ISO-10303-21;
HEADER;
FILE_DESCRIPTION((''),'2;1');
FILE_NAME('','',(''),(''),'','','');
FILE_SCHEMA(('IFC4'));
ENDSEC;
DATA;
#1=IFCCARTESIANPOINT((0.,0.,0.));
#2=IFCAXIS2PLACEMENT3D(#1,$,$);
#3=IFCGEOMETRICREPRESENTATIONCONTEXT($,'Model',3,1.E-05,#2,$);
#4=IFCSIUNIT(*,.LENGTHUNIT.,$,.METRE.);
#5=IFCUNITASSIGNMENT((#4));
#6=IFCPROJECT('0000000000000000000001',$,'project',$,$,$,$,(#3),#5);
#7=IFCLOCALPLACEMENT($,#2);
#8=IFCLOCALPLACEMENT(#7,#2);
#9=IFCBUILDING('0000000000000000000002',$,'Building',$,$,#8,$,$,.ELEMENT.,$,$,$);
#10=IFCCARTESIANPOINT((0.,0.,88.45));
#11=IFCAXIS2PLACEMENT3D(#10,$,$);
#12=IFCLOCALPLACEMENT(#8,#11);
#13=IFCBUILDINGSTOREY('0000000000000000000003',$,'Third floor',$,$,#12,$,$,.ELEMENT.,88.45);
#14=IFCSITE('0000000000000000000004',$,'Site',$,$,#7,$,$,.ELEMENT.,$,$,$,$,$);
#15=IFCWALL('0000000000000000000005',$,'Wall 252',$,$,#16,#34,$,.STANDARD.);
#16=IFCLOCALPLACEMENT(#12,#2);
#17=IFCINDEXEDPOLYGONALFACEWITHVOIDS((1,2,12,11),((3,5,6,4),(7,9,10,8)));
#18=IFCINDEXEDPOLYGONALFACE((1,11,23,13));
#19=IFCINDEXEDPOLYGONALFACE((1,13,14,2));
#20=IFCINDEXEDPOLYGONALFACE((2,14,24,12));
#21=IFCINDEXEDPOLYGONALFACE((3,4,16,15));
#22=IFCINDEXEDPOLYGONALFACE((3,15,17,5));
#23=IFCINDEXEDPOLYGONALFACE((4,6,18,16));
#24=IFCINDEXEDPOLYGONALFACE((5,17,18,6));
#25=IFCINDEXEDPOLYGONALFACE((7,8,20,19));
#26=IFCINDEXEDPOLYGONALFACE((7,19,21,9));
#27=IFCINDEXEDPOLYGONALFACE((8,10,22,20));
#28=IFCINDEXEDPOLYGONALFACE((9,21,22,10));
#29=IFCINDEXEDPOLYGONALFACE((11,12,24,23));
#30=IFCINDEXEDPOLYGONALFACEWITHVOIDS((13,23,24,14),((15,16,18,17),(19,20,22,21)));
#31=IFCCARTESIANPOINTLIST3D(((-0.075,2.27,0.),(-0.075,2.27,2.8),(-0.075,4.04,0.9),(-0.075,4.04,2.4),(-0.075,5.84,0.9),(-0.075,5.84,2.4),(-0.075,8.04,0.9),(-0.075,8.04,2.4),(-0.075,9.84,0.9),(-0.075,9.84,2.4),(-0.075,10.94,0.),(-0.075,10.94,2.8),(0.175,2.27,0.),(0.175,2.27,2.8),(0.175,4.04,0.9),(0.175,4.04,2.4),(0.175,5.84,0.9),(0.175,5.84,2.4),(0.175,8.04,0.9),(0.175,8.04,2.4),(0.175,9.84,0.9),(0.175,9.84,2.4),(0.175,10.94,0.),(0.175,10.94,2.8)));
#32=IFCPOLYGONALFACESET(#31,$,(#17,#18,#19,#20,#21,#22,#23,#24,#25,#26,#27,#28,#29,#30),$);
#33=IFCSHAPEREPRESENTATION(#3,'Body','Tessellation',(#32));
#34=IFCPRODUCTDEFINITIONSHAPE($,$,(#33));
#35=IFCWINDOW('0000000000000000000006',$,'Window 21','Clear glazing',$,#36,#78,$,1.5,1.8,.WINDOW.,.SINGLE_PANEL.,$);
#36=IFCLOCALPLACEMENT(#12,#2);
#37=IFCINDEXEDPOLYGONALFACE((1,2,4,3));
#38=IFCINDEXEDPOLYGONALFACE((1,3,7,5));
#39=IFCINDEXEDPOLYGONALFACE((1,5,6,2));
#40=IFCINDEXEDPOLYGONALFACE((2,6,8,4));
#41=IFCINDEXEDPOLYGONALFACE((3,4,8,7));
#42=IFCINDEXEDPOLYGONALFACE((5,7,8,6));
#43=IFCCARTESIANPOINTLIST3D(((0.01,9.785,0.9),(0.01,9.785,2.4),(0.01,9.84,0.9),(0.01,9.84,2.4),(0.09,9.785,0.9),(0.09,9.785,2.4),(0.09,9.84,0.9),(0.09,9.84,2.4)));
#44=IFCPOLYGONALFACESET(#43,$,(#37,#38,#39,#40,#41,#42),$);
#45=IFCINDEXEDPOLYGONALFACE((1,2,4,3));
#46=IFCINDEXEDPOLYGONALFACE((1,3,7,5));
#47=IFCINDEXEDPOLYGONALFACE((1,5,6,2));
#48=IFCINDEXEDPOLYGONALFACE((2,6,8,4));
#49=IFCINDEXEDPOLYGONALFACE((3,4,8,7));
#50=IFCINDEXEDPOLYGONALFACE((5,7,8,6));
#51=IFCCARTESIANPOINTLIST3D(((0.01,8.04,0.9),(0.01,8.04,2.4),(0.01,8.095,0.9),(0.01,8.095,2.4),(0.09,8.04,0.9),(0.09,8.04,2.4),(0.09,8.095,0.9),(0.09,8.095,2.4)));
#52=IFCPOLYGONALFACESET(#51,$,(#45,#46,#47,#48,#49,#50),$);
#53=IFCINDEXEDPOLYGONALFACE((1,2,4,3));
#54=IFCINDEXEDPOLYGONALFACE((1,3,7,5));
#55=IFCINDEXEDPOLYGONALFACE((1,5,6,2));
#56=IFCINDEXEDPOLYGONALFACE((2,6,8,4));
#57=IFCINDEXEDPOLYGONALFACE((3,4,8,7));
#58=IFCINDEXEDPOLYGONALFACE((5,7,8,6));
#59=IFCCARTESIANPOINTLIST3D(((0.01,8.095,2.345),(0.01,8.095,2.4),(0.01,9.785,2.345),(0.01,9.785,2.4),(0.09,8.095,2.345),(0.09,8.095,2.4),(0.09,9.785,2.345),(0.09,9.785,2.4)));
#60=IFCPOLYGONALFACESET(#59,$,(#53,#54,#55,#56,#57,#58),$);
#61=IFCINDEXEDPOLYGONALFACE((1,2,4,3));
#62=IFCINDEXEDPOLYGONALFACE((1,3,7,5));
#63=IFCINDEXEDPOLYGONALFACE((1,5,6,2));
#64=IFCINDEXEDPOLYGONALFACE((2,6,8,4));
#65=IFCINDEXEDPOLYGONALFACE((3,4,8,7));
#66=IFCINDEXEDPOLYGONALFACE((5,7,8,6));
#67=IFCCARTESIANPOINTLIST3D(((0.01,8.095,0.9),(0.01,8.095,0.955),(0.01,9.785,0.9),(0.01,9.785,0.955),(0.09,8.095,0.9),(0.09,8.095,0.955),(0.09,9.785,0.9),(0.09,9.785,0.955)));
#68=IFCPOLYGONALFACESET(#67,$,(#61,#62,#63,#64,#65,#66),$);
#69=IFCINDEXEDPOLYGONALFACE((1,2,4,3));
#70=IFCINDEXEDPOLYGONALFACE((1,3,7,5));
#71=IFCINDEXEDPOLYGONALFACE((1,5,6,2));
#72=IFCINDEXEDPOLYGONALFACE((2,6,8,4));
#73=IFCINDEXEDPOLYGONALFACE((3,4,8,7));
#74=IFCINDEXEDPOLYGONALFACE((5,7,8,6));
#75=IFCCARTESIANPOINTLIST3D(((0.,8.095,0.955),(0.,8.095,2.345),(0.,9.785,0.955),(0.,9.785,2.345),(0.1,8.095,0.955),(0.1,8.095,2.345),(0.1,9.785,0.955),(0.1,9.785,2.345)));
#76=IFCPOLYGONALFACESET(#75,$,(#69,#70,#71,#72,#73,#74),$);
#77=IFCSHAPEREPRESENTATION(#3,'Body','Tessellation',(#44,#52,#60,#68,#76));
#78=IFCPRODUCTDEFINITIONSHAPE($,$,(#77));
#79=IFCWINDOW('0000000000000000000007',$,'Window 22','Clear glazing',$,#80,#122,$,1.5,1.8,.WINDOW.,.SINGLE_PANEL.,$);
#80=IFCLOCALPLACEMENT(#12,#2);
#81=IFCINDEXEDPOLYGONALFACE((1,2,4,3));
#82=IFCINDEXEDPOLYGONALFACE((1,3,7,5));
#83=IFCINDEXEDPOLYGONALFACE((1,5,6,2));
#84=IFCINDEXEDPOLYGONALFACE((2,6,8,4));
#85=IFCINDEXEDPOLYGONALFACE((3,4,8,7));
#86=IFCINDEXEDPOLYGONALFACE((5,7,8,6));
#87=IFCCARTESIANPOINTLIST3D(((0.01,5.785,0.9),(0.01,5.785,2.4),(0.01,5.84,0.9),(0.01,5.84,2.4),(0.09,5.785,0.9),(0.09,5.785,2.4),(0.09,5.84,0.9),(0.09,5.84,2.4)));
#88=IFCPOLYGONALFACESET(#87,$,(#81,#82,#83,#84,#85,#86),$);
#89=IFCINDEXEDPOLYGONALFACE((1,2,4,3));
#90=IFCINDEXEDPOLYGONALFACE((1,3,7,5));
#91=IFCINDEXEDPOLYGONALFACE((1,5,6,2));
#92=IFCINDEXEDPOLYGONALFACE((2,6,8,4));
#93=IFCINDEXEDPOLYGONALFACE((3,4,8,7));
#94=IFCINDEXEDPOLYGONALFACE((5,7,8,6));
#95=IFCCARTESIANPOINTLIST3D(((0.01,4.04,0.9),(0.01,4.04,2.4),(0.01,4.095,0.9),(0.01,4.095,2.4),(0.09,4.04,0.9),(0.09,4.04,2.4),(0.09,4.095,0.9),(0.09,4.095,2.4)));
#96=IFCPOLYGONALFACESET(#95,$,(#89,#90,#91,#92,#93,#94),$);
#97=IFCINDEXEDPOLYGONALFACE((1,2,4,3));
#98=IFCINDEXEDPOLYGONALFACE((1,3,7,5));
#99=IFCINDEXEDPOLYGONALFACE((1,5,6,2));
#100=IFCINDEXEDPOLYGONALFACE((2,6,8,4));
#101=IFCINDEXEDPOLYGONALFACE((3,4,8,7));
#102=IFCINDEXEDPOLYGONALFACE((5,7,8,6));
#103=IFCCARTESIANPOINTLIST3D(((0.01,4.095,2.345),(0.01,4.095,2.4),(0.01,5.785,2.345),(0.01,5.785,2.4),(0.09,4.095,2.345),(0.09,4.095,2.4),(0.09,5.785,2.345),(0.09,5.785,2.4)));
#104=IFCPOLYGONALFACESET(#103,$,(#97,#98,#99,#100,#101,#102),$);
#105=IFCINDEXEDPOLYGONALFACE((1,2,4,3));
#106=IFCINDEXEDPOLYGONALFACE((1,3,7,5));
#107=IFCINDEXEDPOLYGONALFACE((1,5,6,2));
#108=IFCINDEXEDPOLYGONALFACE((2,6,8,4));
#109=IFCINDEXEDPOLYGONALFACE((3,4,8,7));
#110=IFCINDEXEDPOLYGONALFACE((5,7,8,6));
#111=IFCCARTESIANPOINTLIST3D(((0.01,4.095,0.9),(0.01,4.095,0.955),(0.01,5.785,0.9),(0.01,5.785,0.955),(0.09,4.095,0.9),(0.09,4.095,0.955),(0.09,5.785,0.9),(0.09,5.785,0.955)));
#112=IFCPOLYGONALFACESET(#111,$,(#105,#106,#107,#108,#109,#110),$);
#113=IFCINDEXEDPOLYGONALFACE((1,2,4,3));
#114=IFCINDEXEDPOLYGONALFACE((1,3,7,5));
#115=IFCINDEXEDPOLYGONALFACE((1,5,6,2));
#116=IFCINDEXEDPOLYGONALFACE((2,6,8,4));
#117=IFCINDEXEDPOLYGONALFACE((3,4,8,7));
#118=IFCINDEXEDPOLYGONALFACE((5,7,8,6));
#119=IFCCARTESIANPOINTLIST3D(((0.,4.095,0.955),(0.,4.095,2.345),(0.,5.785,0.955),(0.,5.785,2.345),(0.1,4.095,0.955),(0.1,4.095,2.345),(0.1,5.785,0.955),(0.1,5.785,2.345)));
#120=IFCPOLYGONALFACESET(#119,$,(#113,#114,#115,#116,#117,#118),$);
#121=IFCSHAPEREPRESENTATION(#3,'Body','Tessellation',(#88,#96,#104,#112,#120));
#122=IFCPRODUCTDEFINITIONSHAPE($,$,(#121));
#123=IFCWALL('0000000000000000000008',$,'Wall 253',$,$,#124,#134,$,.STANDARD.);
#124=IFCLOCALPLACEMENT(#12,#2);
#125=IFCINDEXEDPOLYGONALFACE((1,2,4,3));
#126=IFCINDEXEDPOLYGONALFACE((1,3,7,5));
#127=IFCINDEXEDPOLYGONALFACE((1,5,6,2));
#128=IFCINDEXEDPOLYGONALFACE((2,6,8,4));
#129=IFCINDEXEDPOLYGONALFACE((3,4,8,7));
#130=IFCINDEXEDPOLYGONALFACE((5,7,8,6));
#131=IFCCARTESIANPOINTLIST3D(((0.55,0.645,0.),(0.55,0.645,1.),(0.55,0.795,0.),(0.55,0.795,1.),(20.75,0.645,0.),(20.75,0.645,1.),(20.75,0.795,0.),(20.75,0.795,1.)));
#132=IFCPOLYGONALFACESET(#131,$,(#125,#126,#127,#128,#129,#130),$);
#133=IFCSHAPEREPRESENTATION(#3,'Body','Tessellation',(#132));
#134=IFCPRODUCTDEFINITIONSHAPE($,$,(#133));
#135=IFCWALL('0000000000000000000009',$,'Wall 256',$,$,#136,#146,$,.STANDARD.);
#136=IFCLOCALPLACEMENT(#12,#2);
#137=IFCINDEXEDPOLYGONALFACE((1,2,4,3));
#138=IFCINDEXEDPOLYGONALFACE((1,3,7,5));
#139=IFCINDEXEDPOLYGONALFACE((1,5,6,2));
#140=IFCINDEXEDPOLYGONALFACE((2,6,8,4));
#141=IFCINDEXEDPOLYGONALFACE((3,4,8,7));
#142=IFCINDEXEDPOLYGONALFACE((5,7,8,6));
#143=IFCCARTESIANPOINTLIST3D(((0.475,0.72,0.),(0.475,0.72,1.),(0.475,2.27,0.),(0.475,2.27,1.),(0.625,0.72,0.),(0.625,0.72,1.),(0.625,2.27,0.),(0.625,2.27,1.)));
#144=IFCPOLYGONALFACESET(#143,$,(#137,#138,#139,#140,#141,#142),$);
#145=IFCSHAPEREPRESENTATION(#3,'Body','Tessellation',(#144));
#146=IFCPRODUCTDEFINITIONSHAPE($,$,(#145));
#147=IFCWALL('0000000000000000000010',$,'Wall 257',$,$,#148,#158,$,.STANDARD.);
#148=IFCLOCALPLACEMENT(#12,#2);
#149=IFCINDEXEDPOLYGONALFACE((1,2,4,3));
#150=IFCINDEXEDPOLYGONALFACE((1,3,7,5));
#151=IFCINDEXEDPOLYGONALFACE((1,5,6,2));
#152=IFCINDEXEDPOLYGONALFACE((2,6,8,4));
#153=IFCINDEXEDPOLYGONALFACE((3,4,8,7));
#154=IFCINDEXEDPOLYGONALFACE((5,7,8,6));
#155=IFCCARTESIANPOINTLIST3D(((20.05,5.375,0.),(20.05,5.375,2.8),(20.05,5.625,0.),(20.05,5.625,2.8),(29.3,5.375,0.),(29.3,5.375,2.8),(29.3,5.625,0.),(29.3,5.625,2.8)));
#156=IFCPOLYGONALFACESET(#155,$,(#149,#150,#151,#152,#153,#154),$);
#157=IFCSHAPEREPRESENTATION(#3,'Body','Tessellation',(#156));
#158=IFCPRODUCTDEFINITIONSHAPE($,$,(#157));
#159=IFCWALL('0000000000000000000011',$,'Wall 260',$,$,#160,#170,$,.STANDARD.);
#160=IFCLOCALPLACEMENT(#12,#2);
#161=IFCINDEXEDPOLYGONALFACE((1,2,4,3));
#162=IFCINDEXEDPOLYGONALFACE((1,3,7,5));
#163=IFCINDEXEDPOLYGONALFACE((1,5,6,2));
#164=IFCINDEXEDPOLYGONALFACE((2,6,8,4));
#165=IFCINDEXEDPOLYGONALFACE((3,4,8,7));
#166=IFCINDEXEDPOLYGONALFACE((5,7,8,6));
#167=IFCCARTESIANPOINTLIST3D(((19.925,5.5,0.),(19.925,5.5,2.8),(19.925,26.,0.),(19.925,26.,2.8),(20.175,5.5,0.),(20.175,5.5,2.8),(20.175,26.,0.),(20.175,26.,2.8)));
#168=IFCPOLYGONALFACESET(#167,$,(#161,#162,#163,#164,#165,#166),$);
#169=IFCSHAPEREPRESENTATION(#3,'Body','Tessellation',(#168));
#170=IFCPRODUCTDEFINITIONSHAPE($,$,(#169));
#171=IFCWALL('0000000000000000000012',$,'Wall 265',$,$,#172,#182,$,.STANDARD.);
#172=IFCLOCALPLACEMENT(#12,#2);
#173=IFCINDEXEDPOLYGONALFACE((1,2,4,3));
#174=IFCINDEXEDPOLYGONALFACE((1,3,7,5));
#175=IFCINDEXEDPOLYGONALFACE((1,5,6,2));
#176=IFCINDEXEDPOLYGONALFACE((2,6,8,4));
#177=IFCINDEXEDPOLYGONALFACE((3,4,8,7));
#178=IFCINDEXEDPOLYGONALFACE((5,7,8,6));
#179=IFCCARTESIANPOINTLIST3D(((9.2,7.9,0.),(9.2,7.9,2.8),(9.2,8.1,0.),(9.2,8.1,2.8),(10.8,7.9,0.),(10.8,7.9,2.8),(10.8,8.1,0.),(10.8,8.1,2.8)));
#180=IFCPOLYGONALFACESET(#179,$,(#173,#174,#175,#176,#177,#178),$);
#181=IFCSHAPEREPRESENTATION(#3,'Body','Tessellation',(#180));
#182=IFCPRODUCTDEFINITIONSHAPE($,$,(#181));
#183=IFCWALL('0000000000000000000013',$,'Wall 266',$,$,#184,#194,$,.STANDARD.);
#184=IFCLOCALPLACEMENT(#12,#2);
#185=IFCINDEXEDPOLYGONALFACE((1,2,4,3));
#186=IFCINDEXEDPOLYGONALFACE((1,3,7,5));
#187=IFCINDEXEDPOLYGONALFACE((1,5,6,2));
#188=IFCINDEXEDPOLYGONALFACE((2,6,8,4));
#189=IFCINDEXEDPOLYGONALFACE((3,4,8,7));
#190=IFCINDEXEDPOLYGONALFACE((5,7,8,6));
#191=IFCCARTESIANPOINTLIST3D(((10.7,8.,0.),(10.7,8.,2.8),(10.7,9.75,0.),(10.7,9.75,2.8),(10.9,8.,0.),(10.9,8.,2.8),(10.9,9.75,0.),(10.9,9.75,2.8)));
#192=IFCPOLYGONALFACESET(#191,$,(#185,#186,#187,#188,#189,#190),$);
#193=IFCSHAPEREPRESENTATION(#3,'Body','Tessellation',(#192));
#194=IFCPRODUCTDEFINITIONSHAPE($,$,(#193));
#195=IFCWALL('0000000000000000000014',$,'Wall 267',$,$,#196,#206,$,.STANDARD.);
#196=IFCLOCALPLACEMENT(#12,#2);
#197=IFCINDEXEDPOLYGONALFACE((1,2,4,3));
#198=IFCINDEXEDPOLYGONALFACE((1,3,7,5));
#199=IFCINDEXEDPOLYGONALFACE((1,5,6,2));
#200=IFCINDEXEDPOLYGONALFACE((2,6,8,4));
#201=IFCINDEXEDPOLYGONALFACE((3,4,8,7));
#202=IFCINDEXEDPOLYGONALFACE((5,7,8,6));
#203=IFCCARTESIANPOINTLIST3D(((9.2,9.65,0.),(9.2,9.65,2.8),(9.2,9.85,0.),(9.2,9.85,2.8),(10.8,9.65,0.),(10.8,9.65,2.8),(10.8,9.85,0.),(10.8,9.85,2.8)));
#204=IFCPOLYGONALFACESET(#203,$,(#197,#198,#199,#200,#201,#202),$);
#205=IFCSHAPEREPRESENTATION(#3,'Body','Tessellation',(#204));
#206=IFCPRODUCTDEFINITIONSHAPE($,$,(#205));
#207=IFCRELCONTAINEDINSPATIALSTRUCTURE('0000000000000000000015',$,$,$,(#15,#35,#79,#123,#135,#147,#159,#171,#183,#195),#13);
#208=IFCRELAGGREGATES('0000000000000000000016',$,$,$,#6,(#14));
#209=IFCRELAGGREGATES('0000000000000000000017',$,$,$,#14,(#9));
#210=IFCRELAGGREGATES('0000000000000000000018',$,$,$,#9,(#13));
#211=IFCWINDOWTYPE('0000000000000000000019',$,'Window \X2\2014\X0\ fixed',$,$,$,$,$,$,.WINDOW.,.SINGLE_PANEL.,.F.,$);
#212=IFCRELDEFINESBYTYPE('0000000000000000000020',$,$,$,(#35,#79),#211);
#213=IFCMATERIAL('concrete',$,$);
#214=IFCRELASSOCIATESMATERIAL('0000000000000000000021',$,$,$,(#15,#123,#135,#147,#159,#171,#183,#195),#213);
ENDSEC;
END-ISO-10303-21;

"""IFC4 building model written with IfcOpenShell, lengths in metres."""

from ifc_helpers import new_model, si_unit, frame, frame_2d, origin, place, context, project, spatial, rectangle, extrude, material, type_object, element, fill, save


model = new_model("IFC4")

# Units and contexts
model_context = context("Model", 3, precision=1e-05, world=origin())
ifc_project = project(units=[si_unit("LENGTHUNIT", "METRE")], contexts=[model_context])

# Site, building, storey
site_placement = place(None, origin())
site = spatial("IfcSite", under=ifc_project, at=site_placement, Name="Site", CompositionType="ELEMENT")
building_placement = place(site_placement, origin())
building = spatial("IfcBuilding", under=site, at=building_placement, Name="Building", CompositionType="ELEMENT")
storey_placement = place(building_placement, frame((0.0, 0.0, 88.45)))
storey = spatial("IfcBuildingStorey", under=building, at=storey_placement, Name="Third floor", CompositionType="ELEMENT", Elevation=88.45)

# Shared definitions
ifc_material = material(Name="concrete")

# Shared definitions
window_type = type_object("IfcWindowType", Name="Window — fixed", ParameterTakesPrecedence=False, PartitioningType="SINGLE_PANEL", PredefinedType="WINDOW")

# Wall, openings, windows
wall_1_placement = place(storey_placement, frame((0.05, 10.94, 0.0), z_axis=(0.0, 0.0, 1.0), x_axis=(0.0, -1.0, 0.0)))
wall_1 = element("IfcWall", 1, at=wall_1_placement, inside=storey, material=ifc_material, Name="Wall 252", PredefinedType="STANDARD", context=model_context, shape_type="SweptSolid", body=[
    extrude(rectangle(XDim=8.67, YDim=0.25, at=frame_2d((4.335, 0.0))), origin(), (0.0, 0.0, 1.0), 2.8),
])
opening_1_placement = place(storey_placement, frame((0.05, 9.84, 0.9), z_axis=(0.0, 0.0, 1.0), x_axis=(0.0, -1.0, 0.0)))
opening_1 = element("IfcOpeningElement", 2, at=opening_1_placement, cuts=wall_1, PredefinedType="OPENING", context=model_context, shape_type="SweptSolid", body=[
    extrude(rectangle(XDim=1.8, YDim=0.31, at=frame_2d((0.9, 0.0))), origin(), (0.0, 0.0, 1.0), 1.5),
])
opening_2_placement = place(storey_placement, frame((0.05, 5.84, 0.9), z_axis=(0.0, 0.0, 1.0), x_axis=(0.0, -1.0, 0.0)))
opening_2 = element("IfcOpeningElement", 3, at=opening_2_placement, cuts=wall_1, PredefinedType="OPENING", context=model_context, shape_type="SweptSolid", body=[
    extrude(rectangle(XDim=1.8, YDim=0.31, at=frame_2d((0.9, 0.0))), origin(), (0.0, 0.0, 1.0), 1.5),
])
window_1_placement = place(storey_placement, frame((0.05, 9.84, 0.9), z_axis=(0.0, 0.0, 1.0), x_axis=(0.0, -1.0, 0.0)))
window_1 = element("IfcWindow", 4, at=window_1_placement, inside=storey, type_object=window_type, Name="Window 21", Description="Clear glazing", OverallHeight=1.5, OverallWidth=1.8, PartitioningType="SINGLE_PANEL", PredefinedType="WINDOW", context=model_context, shape_type="SweptSolid", body=[
    extrude(rectangle(XDim=0.055, YDim=0.08, at=frame_2d((0.0275, 0.0))), origin(), (0.0, 0.0, 1.0), 1.5),
    extrude(rectangle(XDim=0.055, YDim=0.08, at=frame_2d((1.7725, 0.0))), origin(), (0.0, 0.0, 1.0), 1.5),
    extrude(rectangle(XDim=1.69, YDim=0.08, at=frame_2d((0.9, 0.0))), frame((0.0, 0.0, 1.445)), (0.0, 0.0, 1.0), 0.055),
    extrude(rectangle(XDim=1.69, YDim=0.08, at=frame_2d((0.9, 0.0))), origin(), (0.0, 0.0, 1.0), 0.055),
    extrude(rectangle(XDim=1.69, YDim=0.1, at=frame_2d((0.9, 0.0))), frame((0.0, 0.0, 0.055)), (0.0, 0.0, 1.0), 1.39),
])
fill(opening_1, window_1)
window_2_placement = place(storey_placement, frame((0.05, 5.84, 0.9), z_axis=(0.0, 0.0, 1.0), x_axis=(0.0, -1.0, 0.0)))
window_2 = element("IfcWindow", 5, at=window_2_placement, inside=storey, type_object=window_type, Name="Window 22", Description="Clear glazing", OverallHeight=1.5, OverallWidth=1.8, PartitioningType="SINGLE_PANEL", PredefinedType="WINDOW", context=model_context, shape_type="SweptSolid", body=[
    extrude(rectangle(XDim=0.055, YDim=0.08, at=frame_2d((0.0275, 0.0))), origin(), (0.0, 0.0, 1.0), 1.5),
    extrude(rectangle(XDim=0.055, YDim=0.08, at=frame_2d((1.7725, 0.0))), origin(), (0.0, 0.0, 1.0), 1.5),
    extrude(rectangle(XDim=1.69, YDim=0.08, at=frame_2d((0.9, 0.0))), frame((0.0, 0.0, 1.445)), (0.0, 0.0, 1.0), 0.055),
    extrude(rectangle(XDim=1.69, YDim=0.08, at=frame_2d((0.9, 0.0))), origin(), (0.0, 0.0, 1.0), 0.055),
    extrude(rectangle(XDim=1.69, YDim=0.1, at=frame_2d((0.9, 0.0))), frame((0.0, 0.0, 0.055)), (0.0, 0.0, 1.0), 1.39),
])
fill(opening_2, window_2)

# Walls
wall_2_placement = place(storey_placement, frame((0.55, 0.72, 0.0), z_axis=(0.0, 0.0, 1.0), x_axis=(1.0, 0.0, 0.0)))
element("IfcWall", 6, at=wall_2_placement, inside=storey, material=ifc_material, Name="Wall 253", PredefinedType="STANDARD", context=model_context, shape_type="SweptSolid", body=[
    extrude(rectangle(XDim=20.2, YDim=0.15, at=frame_2d((10.1, 0.0))), origin(), (0.0, 0.0, 1.0), 1.0),
])
wall_3_placement = place(storey_placement, frame((0.55, 2.27, 0.0), z_axis=(0.0, 0.0, 1.0), x_axis=(0.0, -1.0, 0.0)))
element("IfcWall", 7, at=wall_3_placement, inside=storey, material=ifc_material, Name="Wall 256", PredefinedType="STANDARD", context=model_context, shape_type="SweptSolid", body=[
    extrude(rectangle(XDim=1.55, YDim=0.15, at=frame_2d((0.775, 0.0))), origin(), (0.0, 0.0, 1.0), 1.0),
])
wall_4_placement = place(storey_placement, frame((20.05, 5.5, 0.0), z_axis=(0.0, 0.0, 1.0), x_axis=(1.0, 0.0, 0.0)))
element("IfcWall", 8, at=wall_4_placement, inside=storey, material=ifc_material, Name="Wall 257", PredefinedType="STANDARD", context=model_context, shape_type="SweptSolid", body=[
    extrude(rectangle(XDim=9.25, YDim=0.25, at=frame_2d((4.625, 0.0))), origin(), (0.0, 0.0, 1.0), 2.8),
])
wall_5_placement = place(storey_placement, frame((20.05, 26.0, 0.0), z_axis=(0.0, 0.0, 1.0), x_axis=(0.0, -1.0, 0.0)))
element("IfcWall", 9, at=wall_5_placement, inside=storey, material=ifc_material, Name="Wall 260", PredefinedType="STANDARD", context=model_context, shape_type="SweptSolid", body=[
    extrude(rectangle(XDim=20.5, YDim=0.25, at=frame_2d((10.25, 0.0))), origin(), (0.0, 0.0, 1.0), 2.8),
])
wall_6_placement = place(storey_placement, frame((9.2, 8.0, 0.0), z_axis=(0.0, 0.0, 1.0), x_axis=(1.0, 0.0, 0.0)))
element("IfcWall", 10, at=wall_6_placement, inside=storey, material=ifc_material, Name="Wall 265", PredefinedType="STANDARD", context=model_context, shape_type="SweptSolid", body=[
    extrude(rectangle(XDim=1.6, YDim=0.2, at=frame_2d((0.8, 0.0))), origin(), (0.0, 0.0, 1.0), 2.8),
])
wall_7_placement = place(storey_placement, frame((10.8, 8.0, 0.0), z_axis=(0.0, 0.0, 1.0), x_axis=(0.0, 1.0, 0.0)))
element("IfcWall", 11, at=wall_7_placement, inside=storey, material=ifc_material, Name="Wall 266", PredefinedType="STANDARD", context=model_context, shape_type="SweptSolid", body=[
    extrude(rectangle(XDim=1.75, YDim=0.2, at=frame_2d((0.875, 0.0))), origin(), (0.0, 0.0, 1.0), 2.8),
])
wall_8_placement = place(storey_placement, frame((10.8, 9.75, 0.0), z_axis=(0.0, 0.0, 1.0), x_axis=(-1.0, 0.0, 0.0)))
element("IfcWall", 12, at=wall_8_placement, inside=storey, material=ifc_material, Name="Wall 267", PredefinedType="STANDARD", context=model_context, shape_type="SweptSolid", body=[
    extrude(rectangle(XDim=1.6, YDim=0.2, at=frame_2d((0.8, 0.0))), origin(), (0.0, 0.0, 1.0), 2.8),
])

save(model, "model.ifc")
